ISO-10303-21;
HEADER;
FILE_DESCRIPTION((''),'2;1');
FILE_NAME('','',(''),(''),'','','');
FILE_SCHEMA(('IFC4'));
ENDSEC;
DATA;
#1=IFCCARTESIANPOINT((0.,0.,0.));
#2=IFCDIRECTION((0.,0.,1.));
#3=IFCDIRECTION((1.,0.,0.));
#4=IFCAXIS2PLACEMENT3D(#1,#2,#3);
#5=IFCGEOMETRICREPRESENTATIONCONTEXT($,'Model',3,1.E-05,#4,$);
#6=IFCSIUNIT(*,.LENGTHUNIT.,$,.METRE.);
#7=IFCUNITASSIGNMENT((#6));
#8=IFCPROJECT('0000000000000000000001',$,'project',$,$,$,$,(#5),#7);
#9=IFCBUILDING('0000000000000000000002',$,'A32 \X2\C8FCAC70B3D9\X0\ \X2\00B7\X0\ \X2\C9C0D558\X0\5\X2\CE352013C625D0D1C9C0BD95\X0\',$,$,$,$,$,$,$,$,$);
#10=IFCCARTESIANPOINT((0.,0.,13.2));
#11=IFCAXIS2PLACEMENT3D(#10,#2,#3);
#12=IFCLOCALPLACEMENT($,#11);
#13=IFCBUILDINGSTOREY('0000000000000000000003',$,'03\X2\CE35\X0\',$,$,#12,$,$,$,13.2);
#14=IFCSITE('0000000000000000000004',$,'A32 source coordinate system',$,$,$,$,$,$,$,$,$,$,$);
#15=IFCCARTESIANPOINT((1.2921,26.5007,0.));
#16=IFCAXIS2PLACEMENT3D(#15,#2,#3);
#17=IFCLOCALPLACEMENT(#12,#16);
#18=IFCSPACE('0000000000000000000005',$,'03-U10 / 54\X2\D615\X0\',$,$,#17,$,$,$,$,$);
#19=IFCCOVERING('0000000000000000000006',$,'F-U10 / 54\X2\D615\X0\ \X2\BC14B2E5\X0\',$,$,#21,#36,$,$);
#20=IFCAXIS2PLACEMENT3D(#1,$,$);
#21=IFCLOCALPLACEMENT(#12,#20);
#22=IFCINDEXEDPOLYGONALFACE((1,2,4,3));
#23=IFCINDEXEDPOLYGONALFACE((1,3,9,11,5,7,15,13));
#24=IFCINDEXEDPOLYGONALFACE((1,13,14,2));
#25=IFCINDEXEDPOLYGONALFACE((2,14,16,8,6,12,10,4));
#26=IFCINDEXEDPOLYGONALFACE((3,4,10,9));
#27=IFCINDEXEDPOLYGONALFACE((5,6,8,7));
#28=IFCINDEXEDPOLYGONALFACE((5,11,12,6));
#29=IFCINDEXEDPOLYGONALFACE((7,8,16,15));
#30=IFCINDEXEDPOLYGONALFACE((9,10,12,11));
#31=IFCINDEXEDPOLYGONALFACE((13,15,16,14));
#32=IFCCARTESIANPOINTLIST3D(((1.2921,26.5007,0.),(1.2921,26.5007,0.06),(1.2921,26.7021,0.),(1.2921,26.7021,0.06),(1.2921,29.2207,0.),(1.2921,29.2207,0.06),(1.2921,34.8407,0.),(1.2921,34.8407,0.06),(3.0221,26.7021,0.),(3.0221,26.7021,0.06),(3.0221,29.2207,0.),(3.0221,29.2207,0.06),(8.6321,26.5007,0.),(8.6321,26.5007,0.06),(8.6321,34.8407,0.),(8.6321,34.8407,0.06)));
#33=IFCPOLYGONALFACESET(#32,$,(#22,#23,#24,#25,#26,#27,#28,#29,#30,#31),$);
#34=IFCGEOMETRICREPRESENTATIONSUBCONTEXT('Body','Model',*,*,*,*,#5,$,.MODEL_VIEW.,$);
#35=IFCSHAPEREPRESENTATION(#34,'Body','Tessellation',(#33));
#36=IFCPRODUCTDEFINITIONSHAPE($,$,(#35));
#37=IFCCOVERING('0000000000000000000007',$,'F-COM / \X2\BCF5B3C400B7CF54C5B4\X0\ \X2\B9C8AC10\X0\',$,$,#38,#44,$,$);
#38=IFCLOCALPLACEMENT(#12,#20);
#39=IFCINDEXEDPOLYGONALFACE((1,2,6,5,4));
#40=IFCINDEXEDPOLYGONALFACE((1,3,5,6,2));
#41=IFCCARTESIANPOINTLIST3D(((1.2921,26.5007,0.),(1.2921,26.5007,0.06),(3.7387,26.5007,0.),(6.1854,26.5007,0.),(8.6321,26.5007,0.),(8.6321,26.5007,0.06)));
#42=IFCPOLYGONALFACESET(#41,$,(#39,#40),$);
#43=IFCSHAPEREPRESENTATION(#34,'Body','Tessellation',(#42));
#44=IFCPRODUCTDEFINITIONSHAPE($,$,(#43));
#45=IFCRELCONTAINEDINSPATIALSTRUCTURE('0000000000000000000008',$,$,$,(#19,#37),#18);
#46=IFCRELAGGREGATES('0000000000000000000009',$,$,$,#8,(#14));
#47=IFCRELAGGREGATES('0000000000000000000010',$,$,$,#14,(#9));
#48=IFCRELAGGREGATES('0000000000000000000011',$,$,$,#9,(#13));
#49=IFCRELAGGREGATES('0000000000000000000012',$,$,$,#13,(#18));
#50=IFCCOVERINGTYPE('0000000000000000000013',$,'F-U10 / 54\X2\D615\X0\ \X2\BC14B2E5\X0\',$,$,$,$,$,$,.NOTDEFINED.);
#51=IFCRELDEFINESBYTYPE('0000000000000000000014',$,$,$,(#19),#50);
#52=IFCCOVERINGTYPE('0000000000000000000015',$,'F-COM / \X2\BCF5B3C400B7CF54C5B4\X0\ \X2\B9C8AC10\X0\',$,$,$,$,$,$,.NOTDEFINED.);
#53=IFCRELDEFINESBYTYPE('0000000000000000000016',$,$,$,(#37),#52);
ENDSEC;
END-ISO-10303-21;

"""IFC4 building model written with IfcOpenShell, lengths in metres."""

from ifc_helpers import new_model, si_unit, frame, origin, origin_with_axes, place, context, subcontext, project, spatial, polyline, outline, extrude, source, transform, mapped, type_object, type_shapes, element, save


model = new_model("IFC4")

# Units and contexts
model_context = context("Model", 3, precision=1e-05, world=origin_with_axes())
body_context = subcontext(model_context, "Body", "Model", "MODEL_VIEW")
ifc_project = project(units=[si_unit("LENGTHUNIT", "METRE")], contexts=[model_context])

# Site, building, storey, space
storey_placement = place(None, frame((0.0, 0.0, 13.2), z_axis=(0.0, 0.0, 1.0), x_axis=(1.0, 0.0, 0.0)))
space_1_placement = place(storey_placement, frame((1.2921, 26.5007, 0.0), z_axis=(0.0, 0.0, 1.0), x_axis=(1.0, 0.0, 0.0)))
site = spatial("IfcSite", under=ifc_project, Name="A32 source coordinate system")
building = spatial("IfcBuilding", under=site, Name="A32 주거동 · 지하5층–옥탑지붕")
storey = spatial("IfcBuildingStorey", under=building, at=storey_placement, Name="03층", Elevation=13.2)
space_1 = spatial("IfcSpace", under=storey, at=space_1_placement, Name="03-U10 / 54형")

# Coverings
covering_type_1 = type_object("IfcCoveringType", Name="F-U10 / 54형 바닥", PredefinedType="NOTDEFINED")
shared_shape_1 = source(origin(), body_context, "Body", "SweptSolid", [
    extrude(outline(polyline([(7.34, 0.0), (0.0, 0.0), (0.0, 0.2014), (1.73, 0.2014), (1.73, 2.72), (0.0, 2.72), (0.0, 8.34), (7.34, 8.34), (7.34, 0.0)])), origin(), (0.0, 0.0, 1.0), 0.06),
])
type_shapes(covering_type_1, [shared_shape_1])
covering_1_placement = place(space_1_placement, origin_with_axes())
element("IfcCovering", 1, at=covering_1_placement, inside=space_1, type_object=covering_type_1, Name="F-U10 / 54형 바닥", context=body_context, shape_type="MappedRepresentation", body=[
    mapped(shared_shape_1, transform((0.0, 0.0, 0.0), scale=1.0)),
])
covering_type_2 = type_object("IfcCoveringType", Name="F-COM / 복도·코어 마감", PredefinedType="NOTDEFINED")
shared_shape_2 = source(origin(), body_context, "Body", "SweptSolid", [
    extrude(outline(polyline([(7.34, 0.0), (7.34, 0.0), (0.0, 0.0), (0.0, 0.0), (7.34, 0.0)])), origin(), (0.0, 0.0, 1.0), 0.06),
])
type_shapes(covering_type_2, [shared_shape_2])
covering_2_placement = place(space_1_placement, origin_with_axes())
element("IfcCovering", 2, at=covering_2_placement, inside=space_1, type_object=covering_type_2, Name="F-COM / 복도·코어 마감", context=body_context, shape_type="MappedRepresentation", body=[
    mapped(shared_shape_2, transform((0.0, 0.0, 0.0), scale=1.0)),
])

save(model, "model.ifc")
